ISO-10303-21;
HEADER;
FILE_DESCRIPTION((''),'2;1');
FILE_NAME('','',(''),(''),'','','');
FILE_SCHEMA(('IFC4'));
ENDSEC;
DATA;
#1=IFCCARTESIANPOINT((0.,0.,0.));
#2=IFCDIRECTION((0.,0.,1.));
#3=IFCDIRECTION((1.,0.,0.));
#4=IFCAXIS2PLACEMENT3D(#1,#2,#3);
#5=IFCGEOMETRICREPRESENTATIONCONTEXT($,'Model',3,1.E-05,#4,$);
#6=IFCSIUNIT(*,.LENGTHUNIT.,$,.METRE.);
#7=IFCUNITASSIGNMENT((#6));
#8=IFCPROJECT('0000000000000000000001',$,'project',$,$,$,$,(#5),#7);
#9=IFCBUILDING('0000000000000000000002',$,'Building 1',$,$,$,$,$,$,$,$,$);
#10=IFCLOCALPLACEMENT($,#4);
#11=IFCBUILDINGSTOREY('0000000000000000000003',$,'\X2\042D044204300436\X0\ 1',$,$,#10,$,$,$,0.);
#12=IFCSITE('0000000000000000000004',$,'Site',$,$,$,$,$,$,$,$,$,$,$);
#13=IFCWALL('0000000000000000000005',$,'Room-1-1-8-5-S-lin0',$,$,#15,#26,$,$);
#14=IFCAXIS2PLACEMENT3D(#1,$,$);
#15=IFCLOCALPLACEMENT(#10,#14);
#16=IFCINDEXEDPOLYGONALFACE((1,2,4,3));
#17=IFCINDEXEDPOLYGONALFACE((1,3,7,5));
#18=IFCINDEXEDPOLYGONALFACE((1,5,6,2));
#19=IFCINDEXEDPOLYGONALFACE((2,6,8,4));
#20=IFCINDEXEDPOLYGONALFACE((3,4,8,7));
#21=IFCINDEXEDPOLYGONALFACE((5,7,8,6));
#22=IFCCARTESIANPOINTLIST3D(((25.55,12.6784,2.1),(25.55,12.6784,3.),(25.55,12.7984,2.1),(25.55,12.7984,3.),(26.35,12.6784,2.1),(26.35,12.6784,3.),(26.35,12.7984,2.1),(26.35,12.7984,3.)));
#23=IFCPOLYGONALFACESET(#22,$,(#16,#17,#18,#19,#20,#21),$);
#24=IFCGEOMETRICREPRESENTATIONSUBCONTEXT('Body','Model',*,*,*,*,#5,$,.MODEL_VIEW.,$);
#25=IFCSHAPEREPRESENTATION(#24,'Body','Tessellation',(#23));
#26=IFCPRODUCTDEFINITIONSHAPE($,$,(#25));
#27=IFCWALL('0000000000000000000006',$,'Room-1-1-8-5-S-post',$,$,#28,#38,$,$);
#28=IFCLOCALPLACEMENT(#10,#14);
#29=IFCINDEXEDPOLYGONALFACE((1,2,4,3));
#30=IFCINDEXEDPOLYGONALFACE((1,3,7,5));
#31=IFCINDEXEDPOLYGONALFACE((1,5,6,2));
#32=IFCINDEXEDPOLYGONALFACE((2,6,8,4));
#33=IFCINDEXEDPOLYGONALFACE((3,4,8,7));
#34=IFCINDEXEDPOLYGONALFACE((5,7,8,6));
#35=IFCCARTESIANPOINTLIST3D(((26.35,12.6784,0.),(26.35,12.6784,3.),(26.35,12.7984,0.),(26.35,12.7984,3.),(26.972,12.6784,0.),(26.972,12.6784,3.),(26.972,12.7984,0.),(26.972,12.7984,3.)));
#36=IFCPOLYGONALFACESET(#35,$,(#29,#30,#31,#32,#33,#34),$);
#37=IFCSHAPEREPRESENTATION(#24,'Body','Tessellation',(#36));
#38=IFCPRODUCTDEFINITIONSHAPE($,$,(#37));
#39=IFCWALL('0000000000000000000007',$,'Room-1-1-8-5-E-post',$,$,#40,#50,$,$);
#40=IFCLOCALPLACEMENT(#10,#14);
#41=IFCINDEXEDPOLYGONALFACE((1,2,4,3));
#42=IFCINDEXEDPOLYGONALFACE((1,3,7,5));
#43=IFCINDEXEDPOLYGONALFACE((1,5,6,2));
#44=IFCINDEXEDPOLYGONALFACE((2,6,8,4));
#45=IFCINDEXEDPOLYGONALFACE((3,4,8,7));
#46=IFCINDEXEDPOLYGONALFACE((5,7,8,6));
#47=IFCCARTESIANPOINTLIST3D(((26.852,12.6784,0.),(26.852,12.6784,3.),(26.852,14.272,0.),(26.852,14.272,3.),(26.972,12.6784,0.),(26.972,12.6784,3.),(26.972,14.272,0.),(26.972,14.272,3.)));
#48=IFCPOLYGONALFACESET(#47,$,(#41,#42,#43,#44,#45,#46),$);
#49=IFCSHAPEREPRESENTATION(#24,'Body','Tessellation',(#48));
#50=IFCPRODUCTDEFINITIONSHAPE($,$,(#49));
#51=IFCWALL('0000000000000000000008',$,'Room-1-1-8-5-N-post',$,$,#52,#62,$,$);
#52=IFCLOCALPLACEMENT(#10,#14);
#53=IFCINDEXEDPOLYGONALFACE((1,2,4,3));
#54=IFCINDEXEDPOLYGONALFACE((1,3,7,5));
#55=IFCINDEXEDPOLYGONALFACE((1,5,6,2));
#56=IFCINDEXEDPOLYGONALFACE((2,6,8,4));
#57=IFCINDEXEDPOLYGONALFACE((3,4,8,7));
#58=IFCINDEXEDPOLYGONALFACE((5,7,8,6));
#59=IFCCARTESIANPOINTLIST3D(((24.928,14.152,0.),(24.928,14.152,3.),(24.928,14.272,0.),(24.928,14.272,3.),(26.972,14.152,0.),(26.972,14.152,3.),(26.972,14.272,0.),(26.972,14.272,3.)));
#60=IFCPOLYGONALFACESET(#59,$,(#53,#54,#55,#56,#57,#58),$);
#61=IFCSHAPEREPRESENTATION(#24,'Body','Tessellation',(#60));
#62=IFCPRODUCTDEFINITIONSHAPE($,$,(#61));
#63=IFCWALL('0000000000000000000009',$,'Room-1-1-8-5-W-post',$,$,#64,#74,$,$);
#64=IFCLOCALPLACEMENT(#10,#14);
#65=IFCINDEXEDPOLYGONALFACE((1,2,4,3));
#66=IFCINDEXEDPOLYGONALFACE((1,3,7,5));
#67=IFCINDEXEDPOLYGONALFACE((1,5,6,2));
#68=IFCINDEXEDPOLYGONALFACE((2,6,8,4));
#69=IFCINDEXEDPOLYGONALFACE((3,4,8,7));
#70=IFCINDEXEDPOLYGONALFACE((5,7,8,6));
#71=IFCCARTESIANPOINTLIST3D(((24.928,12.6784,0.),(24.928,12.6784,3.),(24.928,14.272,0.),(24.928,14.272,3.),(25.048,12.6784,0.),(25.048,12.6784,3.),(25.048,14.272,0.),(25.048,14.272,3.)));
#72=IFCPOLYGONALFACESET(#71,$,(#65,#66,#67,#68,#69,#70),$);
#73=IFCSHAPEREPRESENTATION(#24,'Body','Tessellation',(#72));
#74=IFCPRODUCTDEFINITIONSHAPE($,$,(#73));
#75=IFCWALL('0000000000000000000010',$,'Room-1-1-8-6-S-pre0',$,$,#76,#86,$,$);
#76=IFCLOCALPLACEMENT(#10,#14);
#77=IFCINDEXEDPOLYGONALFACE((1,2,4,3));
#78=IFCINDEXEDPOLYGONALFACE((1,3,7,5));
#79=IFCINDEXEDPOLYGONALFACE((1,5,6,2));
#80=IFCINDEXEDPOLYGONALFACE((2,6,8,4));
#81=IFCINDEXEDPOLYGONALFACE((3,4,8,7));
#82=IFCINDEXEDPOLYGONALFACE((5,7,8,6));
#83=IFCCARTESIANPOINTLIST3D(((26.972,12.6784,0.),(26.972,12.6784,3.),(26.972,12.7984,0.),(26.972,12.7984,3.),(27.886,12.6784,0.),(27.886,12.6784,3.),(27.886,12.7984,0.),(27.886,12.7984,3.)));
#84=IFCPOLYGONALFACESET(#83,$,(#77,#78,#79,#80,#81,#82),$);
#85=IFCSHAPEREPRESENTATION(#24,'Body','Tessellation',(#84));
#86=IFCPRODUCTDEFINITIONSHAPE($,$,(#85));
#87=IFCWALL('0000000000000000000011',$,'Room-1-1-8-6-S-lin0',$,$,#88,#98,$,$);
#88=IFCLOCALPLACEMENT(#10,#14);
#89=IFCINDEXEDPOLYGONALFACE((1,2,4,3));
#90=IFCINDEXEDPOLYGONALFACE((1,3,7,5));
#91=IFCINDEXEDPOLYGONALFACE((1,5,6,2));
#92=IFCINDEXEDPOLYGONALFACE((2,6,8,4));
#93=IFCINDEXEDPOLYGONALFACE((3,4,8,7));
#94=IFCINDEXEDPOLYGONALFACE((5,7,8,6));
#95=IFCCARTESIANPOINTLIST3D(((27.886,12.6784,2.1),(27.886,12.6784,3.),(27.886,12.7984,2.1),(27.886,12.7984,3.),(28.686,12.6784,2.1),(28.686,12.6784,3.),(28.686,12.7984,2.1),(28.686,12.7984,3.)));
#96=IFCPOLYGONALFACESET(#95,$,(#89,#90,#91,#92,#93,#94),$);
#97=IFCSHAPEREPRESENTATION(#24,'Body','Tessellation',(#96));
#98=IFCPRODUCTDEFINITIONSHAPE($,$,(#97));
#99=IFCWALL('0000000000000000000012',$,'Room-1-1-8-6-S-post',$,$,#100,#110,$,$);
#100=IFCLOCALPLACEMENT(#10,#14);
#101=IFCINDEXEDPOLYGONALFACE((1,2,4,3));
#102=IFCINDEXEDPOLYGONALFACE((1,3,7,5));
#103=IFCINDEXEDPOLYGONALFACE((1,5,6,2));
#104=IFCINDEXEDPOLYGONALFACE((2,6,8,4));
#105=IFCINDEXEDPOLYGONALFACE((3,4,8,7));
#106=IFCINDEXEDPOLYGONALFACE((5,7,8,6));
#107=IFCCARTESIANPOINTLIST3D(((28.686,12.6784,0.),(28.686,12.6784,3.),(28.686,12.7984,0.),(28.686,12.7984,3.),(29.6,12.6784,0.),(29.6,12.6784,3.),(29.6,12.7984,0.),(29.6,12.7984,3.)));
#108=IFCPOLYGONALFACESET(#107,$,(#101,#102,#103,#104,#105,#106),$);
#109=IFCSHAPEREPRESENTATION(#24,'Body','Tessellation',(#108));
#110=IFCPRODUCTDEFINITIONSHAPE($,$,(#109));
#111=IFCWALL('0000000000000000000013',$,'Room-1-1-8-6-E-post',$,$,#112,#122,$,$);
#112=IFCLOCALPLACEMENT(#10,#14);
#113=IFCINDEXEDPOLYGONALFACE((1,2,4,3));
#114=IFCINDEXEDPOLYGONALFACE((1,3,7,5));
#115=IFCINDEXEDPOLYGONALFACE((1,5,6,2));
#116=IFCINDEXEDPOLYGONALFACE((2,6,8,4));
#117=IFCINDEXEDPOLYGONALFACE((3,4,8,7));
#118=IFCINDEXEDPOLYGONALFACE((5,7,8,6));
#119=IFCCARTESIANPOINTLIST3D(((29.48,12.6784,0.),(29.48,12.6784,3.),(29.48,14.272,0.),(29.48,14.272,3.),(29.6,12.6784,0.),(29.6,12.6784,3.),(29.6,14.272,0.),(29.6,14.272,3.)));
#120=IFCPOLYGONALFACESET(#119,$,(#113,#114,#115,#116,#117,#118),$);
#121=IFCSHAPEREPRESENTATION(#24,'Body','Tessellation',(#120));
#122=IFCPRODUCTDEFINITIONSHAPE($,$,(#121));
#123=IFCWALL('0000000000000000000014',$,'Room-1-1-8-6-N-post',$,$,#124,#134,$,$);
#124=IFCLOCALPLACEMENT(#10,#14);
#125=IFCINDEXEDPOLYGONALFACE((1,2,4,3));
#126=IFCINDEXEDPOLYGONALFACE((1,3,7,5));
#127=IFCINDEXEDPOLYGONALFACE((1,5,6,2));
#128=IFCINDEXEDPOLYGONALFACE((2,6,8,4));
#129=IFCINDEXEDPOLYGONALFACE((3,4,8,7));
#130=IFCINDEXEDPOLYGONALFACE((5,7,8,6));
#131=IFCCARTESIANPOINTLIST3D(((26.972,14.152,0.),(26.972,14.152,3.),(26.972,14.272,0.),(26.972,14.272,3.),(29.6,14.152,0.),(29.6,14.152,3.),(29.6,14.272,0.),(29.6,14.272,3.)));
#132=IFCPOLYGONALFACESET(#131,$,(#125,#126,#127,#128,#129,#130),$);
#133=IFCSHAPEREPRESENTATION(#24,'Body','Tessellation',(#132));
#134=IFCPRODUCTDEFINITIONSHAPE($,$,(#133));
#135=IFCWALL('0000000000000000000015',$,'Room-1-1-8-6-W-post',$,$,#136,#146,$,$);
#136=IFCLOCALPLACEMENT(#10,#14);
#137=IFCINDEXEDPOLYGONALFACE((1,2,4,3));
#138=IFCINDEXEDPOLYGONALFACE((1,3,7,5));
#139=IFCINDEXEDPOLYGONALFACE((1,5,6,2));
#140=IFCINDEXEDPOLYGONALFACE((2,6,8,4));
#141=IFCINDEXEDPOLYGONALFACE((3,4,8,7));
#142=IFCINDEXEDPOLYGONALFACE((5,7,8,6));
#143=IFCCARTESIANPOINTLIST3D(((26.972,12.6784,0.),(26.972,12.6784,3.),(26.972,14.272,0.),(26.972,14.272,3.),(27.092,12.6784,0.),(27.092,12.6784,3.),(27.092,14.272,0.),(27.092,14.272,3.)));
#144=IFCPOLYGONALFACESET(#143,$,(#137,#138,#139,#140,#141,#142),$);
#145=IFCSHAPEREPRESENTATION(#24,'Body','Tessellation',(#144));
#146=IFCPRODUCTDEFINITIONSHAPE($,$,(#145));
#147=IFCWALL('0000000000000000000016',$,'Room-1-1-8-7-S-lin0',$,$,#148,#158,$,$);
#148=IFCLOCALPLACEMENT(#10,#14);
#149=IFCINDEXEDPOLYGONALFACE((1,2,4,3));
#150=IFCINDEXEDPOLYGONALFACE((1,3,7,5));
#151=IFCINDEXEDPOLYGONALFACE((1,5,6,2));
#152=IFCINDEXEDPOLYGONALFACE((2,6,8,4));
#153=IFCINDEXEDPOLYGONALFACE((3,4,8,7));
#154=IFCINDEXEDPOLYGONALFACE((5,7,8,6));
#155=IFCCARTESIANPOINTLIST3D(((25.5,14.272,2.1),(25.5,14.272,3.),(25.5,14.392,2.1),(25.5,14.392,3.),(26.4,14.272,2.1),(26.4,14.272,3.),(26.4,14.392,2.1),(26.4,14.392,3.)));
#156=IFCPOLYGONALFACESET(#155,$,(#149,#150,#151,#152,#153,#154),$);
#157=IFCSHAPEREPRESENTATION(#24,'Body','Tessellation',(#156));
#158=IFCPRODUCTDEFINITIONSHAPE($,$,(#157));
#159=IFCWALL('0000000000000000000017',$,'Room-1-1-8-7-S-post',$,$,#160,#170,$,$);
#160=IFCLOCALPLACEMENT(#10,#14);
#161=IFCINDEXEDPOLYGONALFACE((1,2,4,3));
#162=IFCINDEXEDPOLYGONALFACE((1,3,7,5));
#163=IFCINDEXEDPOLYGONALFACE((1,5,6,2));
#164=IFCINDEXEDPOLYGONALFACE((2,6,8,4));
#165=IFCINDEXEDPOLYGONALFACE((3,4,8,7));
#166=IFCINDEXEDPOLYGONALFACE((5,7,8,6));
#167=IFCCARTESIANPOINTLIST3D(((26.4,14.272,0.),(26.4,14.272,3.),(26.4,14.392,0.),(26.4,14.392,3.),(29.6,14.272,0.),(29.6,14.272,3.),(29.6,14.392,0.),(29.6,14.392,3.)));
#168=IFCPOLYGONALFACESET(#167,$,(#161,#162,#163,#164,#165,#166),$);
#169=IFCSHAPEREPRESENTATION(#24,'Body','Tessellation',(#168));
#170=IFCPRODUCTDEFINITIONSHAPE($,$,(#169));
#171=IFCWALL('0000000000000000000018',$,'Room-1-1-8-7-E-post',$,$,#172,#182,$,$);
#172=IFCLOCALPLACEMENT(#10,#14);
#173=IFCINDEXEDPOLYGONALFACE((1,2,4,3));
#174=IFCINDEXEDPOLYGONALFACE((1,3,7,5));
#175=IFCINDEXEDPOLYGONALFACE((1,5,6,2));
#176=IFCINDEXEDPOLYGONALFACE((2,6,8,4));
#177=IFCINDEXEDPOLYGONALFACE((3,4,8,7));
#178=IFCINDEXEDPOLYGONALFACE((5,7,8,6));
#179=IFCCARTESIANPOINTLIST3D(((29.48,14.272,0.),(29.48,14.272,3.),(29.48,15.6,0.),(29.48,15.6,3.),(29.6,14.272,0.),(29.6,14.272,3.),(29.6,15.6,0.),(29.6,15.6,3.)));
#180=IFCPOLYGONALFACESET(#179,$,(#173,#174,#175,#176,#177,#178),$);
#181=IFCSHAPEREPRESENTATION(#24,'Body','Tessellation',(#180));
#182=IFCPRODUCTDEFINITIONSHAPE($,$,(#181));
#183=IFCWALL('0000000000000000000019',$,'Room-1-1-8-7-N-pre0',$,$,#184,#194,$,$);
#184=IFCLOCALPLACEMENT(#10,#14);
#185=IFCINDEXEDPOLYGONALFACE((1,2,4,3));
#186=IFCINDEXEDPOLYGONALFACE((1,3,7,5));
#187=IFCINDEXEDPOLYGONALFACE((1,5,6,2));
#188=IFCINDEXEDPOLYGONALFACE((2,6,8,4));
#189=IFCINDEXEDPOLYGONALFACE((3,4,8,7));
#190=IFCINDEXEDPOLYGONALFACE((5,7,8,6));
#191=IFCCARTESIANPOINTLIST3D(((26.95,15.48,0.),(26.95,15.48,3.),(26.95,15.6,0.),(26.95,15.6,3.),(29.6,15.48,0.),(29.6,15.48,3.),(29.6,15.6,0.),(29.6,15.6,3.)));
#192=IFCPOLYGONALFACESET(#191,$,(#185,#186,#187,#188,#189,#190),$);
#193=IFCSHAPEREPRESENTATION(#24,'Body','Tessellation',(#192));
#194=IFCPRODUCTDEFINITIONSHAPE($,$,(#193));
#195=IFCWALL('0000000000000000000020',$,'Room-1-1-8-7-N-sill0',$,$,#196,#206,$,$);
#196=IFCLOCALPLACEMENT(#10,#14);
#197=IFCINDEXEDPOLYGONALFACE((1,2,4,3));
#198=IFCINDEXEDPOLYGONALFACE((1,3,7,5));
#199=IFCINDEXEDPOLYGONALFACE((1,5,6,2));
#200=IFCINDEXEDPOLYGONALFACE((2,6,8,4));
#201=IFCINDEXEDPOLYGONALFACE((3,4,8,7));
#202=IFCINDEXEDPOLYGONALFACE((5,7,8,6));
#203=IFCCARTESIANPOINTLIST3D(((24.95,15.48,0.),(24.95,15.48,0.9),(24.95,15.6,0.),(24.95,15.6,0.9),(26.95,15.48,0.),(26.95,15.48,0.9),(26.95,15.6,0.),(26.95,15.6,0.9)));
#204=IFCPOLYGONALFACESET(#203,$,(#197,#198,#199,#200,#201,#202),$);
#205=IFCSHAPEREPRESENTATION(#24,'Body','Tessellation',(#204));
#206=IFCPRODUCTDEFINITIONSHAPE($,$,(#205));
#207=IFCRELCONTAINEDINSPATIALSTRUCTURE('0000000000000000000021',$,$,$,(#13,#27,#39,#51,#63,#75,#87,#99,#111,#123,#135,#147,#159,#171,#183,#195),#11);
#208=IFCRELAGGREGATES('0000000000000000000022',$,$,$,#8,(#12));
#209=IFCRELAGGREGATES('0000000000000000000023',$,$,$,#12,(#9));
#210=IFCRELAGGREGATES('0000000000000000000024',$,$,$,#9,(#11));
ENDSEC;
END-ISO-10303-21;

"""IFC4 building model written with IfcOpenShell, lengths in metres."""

from ifc_helpers import new_model, si_unit, frame, origin_with_axes, place, context, subcontext, project, spatial, indexed_curve, outline, extrude, element, save


model = new_model("IFC4")

# Units and contexts
model_context = context("Model", 3, precision=1e-05, world=origin_with_axes())
body_context = subcontext(model_context, "Body", "Model", "MODEL_VIEW")
ifc_project = project(units=[si_unit("LENGTHUNIT", "METRE")], contexts=[model_context])

# Site, building, storey
site = spatial("IfcSite", under=ifc_project, Name="Site")
building = spatial("IfcBuilding", under=site, Name="Building 1")
storey_placement = place(None, origin_with_axes())
storey = spatial("IfcBuildingStorey", under=building, at=storey_placement, Name="Этаж 1", Elevation=0.0)

# Walls
wall_1_placement = place(storey_placement, frame((25.55, 12.6784, 2.1), z_axis=(0.0, 0.0, 1.0), x_axis=(1.0, 0.0, 0.0)))
element("IfcWall", 1, at=wall_1_placement, inside=storey, Name="Room-1-1-8-5-S-lin0", context=body_context, shape_type="SweptSolid", body=[
    extrude(outline(indexed_curve([(0.0, 0.0), (0.0, 0.12), (0.8, 0.12), (0.8, 0.0), (0.0, 0.0)], self_intersect=False)), origin_with_axes(), (0.0, 0.0, 1.0), 0.9),
])
wall_2_placement = place(storey_placement, frame((26.35, 12.6784, 0.0), z_axis=(0.0, 0.0, 1.0), x_axis=(1.0, 0.0, 0.0)))
element("IfcWall", 2, at=wall_2_placement, inside=storey, Name="Room-1-1-8-5-S-post", context=body_context, shape_type="SweptSolid", body=[
    extrude(outline(indexed_curve([(0.0, 0.0), (0.0, 0.12), (0.622, 0.12), (0.622, 0.0), (0.0, 0.0)], self_intersect=False)), origin_with_axes(), (0.0, 0.0, 1.0), 3.0),
])
wall_3_placement = place(storey_placement, frame((26.972, 12.6784, 0.0), z_axis=(0.0, 0.0, 1.0), x_axis=(0.0, 1.0, 0.0)))
element("IfcWall", 3, at=wall_3_placement, inside=storey, Name="Room-1-1-8-5-E-post", context=body_context, shape_type="SweptSolid", body=[
    extrude(outline(indexed_curve([(0.0, 0.0), (0.0, 0.12), (1.5936, 0.12), (1.5936, 0.0), (0.0, 0.0)], self_intersect=False)), origin_with_axes(), (0.0, 0.0, 1.0), 3.0),
])
wall_4_placement = place(storey_placement, frame((26.972, 14.272, 0.0), z_axis=(0.0, 0.0, 1.0), x_axis=(-1.0, 0.0, 0.0)))
element("IfcWall", 4, at=wall_4_placement, inside=storey, Name="Room-1-1-8-5-N-post", context=body_context, shape_type="SweptSolid", body=[
    extrude(outline(indexed_curve([(0.0, 0.0), (0.0, 0.12), (2.044, 0.12), (2.044, 0.0), (0.0, 0.0)], self_intersect=False)), origin_with_axes(), (0.0, 0.0, 1.0), 3.0),
])
wall_5_placement = place(storey_placement, frame((24.928, 14.272, 0.0), z_axis=(0.0, 0.0, 1.0), x_axis=(0.0, -1.0, 0.0)))
element("IfcWall", 5, at=wall_5_placement, inside=storey, Name="Room-1-1-8-5-W-post", context=body_context, shape_type="SweptSolid", body=[
    extrude(outline(indexed_curve([(0.0, 0.0), (0.0, 0.12), (1.5936, 0.12), (1.5936, 0.0), (0.0, 0.0)], self_intersect=False)), origin_with_axes(), (0.0, 0.0, 1.0), 3.0),
])
wall_6_placement = place(storey_placement, frame((26.972, 12.6784, 0.0), z_axis=(0.0, 0.0, 1.0), x_axis=(1.0, 0.0, 0.0)))
element("IfcWall", 6, at=wall_6_placement, inside=storey, Name="Room-1-1-8-6-S-pre0", context=body_context, shape_type="SweptSolid", body=[
    extrude(outline(indexed_curve([(0.0, 0.0), (0.0, 0.12), (0.914, 0.12), (0.914, 0.0), (0.0, 0.0)], self_intersect=False)), origin_with_axes(), (0.0, 0.0, 1.0), 3.0),
])
wall_7_placement = place(storey_placement, frame((27.886, 12.6784, 2.1), z_axis=(0.0, 0.0, 1.0), x_axis=(1.0, 0.0, 0.0)))
element("IfcWall", 7, at=wall_7_placement, inside=storey, Name="Room-1-1-8-6-S-lin0", context=body_context, shape_type="SweptSolid", body=[
    extrude(outline(indexed_curve([(0.0, 0.0), (0.0, 0.12), (0.8, 0.12), (0.8, 0.0), (0.0, 0.0)], self_intersect=False)), origin_with_axes(), (0.0, 0.0, 1.0), 0.9),
])
wall_8_placement = place(storey_placement, frame((28.686, 12.6784, 0.0), z_axis=(0.0, 0.0, 1.0), x_axis=(1.0, 0.0, 0.0)))
element("IfcWall", 8, at=wall_8_placement, inside=storey, Name="Room-1-1-8-6-S-post", context=body_context, shape_type="SweptSolid", body=[
    extrude(outline(indexed_curve([(0.0, 0.0), (0.0, 0.12), (0.914, 0.12), (0.914, 0.0), (0.0, 0.0)], self_intersect=False)), origin_with_axes(), (0.0, 0.0, 1.0), 3.0),
])
wall_9_placement = place(storey_placement, frame((29.6, 12.6784, 0.0), z_axis=(0.0, 0.0, 1.0), x_axis=(0.0, 1.0, 0.0)))
element("IfcWall", 9, at=wall_9_placement, inside=storey, Name="Room-1-1-8-6-E-post", context=body_context, shape_type="SweptSolid", body=[
    extrude(outline(indexed_curve([(0.0, 0.0), (0.0, 0.12), (1.5936, 0.12), (1.5936, 0.0), (0.0, 0.0)], self_intersect=False)), origin_with_axes(), (0.0, 0.0, 1.0), 3.0),
])
wall_10_placement = place(storey_placement, frame((29.6, 14.272, 0.0), z_axis=(0.0, 0.0, 1.0), x_axis=(-1.0, 0.0, 0.0)))
element("IfcWall", 10, at=wall_10_placement, inside=storey, Name="Room-1-1-8-6-N-post", context=body_context, shape_type="SweptSolid", body=[
    extrude(outline(indexed_curve([(0.0, 0.0), (0.0, 0.12), (2.628, 0.12), (2.628, 0.0), (0.0, 0.0)], self_intersect=False)), origin_with_axes(), (0.0, 0.0, 1.0), 3.0),
])
wall_11_placement = place(storey_placement, frame((26.972, 14.272, 0.0), z_axis=(0.0, 0.0, 1.0), x_axis=(0.0, -1.0, 0.0)))
element("IfcWall", 11, at=wall_11_placement, inside=storey, Name="Room-1-1-8-6-W-post", context=body_context, shape_type="SweptSolid", body=[
    extrude(outline(indexed_curve([(0.0, 0.0), (0.0, 0.12), (1.5936, 0.12), (1.5936, 0.0), (0.0, 0.0)], self_intersect=False)), origin_with_axes(), (0.0, 0.0, 1.0), 3.0),
])
wall_12_placement = place(storey_placement, frame((25.5, 14.272, 2.1), z_axis=(0.0, 0.0, 1.0), x_axis=(1.0, 0.0, 0.0)))
element("IfcWall", 12, at=wall_12_placement, inside=storey, Name="Room-1-1-8-7-S-lin0", context=body_context, shape_type="SweptSolid", body=[
    extrude(outline(indexed_curve([(0.0, 0.0), (0.0, 0.12), (0.9, 0.12), (0.9, 0.0), (0.0, 0.0)], self_intersect=False)), origin_with_axes(), (0.0, 0.0, 1.0), 0.9),
])
wall_13_placement = place(storey_placement, frame((26.4, 14.272, 0.0), z_axis=(0.0, 0.0, 1.0), x_axis=(1.0, 0.0, 0.0)))
element("IfcWall", 13, at=wall_13_placement, inside=storey, Name="Room-1-1-8-7-S-post", context=body_context, shape_type="SweptSolid", body=[
    extrude(outline(indexed_curve([(0.0, 0.0), (0.0, 0.12), (3.2, 0.12), (3.2, 0.0), (0.0, 0.0)], self_intersect=False)), origin_with_axes(), (0.0, 0.0, 1.0), 3.0),
])
wall_14_placement = place(storey_placement, frame((29.6, 14.272, 0.0), z_axis=(0.0, 0.0, 1.0), x_axis=(0.0, 1.0, 0.0)))
element("IfcWall", 14, at=wall_14_placement, inside=storey, Name="Room-1-1-8-7-E-post", context=body_context, shape_type="SweptSolid", body=[
    extrude(outline(indexed_curve([(0.0, 0.0), (0.0, 0.12), (1.328, 0.12), (1.328, 0.0), (0.0, 0.0)], self_intersect=False)), origin_with_axes(), (0.0, 0.0, 1.0), 3.0),
])
wall_15_placement = place(storey_placement, frame((29.6, 15.6, 0.0), z_axis=(0.0, 0.0, 1.0), x_axis=(-1.0, 0.0, 0.0)))
element("IfcWall", 15, at=wall_15_placement, inside=storey, Name="Room-1-1-8-7-N-pre0", context=body_context, shape_type="SweptSolid", body=[
    extrude(outline(indexed_curve([(0.0, 0.0), (0.0, 0.12), (2.65, 0.12), (2.65, 0.0), (0.0, 0.0)], self_intersect=False)), origin_with_axes(), (0.0, 0.0, 1.0), 3.0),
])
wall_16_placement = place(storey_placement, frame((26.95, 15.6, 0.0), z_axis=(0.0, 0.0, 1.0), x_axis=(-1.0, 0.0, 0.0)))
element("IfcWall", 16, at=wall_16_placement, inside=storey, Name="Room-1-1-8-7-N-sill0", context=body_context, shape_type="SweptSolid", body=[
    extrude(outline(indexed_curve([(0.0, 0.0), (0.0, 0.12), (2.0, 0.12), (2.0, 0.0), (0.0, 0.0)], self_intersect=False)), origin_with_axes(), (0.0, 0.0, 1.0), 0.9),
])

save(model, "model.ifc")
